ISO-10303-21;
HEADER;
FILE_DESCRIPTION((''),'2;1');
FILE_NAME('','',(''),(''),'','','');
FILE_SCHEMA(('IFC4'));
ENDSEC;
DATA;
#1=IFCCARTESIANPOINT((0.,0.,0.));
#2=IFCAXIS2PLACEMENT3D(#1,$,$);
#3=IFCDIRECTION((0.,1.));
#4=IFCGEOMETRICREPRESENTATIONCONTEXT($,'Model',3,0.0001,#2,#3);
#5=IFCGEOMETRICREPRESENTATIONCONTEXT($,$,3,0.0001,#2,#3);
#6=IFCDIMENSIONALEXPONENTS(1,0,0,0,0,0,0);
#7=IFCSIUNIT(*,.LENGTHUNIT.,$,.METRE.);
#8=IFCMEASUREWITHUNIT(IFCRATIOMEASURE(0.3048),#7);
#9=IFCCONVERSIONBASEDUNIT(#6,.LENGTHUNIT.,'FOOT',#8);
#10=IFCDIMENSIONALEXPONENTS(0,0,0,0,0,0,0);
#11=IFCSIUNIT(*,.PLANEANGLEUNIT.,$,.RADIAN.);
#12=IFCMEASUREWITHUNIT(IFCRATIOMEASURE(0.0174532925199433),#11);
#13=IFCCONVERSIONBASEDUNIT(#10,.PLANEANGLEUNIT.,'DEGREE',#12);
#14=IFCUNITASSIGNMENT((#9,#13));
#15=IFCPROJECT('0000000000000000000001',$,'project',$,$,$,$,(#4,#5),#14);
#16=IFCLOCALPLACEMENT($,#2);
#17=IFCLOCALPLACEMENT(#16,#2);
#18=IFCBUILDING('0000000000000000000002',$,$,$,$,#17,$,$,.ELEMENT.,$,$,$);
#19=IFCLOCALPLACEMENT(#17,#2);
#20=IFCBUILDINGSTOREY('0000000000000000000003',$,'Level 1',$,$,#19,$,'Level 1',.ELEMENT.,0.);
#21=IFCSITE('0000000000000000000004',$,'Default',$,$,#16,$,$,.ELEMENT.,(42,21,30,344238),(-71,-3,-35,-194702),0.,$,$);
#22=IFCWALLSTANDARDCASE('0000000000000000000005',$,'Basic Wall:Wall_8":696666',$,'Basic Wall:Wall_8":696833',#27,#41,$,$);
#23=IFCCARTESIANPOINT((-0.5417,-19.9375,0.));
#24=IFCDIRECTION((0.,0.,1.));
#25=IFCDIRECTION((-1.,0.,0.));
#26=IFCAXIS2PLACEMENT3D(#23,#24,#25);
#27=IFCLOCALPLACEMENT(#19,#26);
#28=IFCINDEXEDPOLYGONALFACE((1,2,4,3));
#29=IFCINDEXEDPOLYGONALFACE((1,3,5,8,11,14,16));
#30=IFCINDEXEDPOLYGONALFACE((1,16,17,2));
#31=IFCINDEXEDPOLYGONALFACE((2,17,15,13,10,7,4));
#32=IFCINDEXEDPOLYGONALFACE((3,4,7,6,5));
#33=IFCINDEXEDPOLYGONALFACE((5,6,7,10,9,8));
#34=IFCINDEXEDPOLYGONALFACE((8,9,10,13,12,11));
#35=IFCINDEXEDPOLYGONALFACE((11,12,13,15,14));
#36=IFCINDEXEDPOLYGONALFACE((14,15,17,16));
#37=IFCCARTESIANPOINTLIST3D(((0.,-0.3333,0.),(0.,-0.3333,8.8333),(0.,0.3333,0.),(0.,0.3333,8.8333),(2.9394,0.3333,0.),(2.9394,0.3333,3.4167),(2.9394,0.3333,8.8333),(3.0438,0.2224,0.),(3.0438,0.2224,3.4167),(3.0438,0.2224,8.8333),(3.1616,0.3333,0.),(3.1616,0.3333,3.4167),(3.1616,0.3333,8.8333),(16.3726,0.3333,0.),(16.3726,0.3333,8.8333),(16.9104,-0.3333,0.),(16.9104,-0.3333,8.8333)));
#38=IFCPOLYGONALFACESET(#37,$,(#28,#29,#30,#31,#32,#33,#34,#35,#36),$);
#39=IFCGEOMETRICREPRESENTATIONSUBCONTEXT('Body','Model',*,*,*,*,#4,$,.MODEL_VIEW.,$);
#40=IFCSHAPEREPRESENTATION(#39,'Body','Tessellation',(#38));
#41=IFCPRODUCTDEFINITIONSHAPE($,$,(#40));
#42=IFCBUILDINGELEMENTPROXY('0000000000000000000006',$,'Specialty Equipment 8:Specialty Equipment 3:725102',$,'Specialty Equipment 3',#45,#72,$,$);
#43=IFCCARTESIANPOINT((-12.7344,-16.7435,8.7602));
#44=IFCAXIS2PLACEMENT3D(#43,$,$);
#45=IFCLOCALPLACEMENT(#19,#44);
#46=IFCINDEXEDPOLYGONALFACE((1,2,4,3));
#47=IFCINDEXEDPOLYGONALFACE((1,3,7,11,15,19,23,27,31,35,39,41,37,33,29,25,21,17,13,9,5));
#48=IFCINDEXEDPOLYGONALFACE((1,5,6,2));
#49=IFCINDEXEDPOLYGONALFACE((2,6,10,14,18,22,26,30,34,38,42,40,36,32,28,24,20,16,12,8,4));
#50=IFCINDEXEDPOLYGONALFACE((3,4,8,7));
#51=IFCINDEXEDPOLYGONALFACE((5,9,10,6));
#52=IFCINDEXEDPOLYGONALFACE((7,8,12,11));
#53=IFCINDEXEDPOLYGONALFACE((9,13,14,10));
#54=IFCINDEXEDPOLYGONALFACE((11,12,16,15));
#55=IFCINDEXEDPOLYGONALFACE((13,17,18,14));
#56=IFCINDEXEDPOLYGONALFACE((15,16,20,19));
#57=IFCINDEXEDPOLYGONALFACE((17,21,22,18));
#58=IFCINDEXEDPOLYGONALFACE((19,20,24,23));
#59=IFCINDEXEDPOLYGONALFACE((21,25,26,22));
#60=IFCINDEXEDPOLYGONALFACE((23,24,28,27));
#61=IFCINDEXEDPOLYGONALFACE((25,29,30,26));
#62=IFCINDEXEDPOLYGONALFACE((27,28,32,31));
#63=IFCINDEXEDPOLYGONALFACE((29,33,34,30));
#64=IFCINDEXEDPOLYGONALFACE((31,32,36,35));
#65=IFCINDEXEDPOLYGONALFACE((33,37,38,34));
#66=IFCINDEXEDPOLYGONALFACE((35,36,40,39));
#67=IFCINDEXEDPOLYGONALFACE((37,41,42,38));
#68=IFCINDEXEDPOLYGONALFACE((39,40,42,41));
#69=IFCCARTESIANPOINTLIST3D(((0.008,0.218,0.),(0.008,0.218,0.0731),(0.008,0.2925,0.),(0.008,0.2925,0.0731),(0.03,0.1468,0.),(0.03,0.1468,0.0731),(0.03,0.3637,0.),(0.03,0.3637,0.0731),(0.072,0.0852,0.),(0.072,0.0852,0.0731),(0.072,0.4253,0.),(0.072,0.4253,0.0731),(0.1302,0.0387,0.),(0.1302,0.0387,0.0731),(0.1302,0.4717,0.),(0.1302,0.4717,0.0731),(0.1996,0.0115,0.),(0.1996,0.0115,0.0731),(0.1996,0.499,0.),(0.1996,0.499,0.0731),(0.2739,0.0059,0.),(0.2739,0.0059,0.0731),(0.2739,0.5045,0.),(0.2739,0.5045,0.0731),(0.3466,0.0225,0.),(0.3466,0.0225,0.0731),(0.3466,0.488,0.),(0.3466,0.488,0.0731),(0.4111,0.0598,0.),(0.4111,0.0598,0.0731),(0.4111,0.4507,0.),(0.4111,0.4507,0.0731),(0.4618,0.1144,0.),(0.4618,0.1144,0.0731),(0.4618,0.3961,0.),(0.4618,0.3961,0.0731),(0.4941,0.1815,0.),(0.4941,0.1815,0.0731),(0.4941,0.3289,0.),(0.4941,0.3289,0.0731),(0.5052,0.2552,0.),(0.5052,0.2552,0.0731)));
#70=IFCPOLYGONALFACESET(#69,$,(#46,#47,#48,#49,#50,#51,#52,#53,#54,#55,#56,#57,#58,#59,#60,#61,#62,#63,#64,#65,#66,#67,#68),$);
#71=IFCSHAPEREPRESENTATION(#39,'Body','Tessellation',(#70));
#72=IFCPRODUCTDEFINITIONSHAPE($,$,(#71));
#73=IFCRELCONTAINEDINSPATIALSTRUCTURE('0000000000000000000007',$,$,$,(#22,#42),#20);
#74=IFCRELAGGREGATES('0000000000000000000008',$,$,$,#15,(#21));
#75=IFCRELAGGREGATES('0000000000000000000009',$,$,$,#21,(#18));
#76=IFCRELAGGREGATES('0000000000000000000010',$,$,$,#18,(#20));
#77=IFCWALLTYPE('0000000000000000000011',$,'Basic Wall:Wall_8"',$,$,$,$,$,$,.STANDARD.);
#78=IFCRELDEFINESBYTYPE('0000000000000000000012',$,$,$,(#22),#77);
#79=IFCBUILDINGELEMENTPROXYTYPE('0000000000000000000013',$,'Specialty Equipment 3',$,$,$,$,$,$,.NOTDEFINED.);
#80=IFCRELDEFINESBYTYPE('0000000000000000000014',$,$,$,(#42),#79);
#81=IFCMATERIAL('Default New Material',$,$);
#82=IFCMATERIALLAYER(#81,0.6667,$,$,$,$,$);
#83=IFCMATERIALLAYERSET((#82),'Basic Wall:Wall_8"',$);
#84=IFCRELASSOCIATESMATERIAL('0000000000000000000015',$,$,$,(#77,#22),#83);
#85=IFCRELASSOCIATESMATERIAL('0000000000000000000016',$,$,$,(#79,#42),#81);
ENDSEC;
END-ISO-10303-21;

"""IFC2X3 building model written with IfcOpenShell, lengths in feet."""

from ifc_helpers import new_model, entity, si_unit, converted_unit, direction, frame, frame_2d, origin, place, context, subcontext, project, spatial, polyline, rectangle, circle, outline, extrude, source, transform, mapped, material, layer, layer_set, layer_usage, type_object, type_shapes, element, save


model = new_model("IFC2X3")

# Units and contexts
model_context = context("Model", 3, precision=0.0001, world=origin(), true_north=direction((0.0, 1.0)))
context_of_model = context(None, 3, precision=0.0001, world=origin(), true_north=direction((0.0, 1.0)))
body_context = subcontext(model_context, "Body", "Model", "MODEL_VIEW")
ifc_project = project(units=[converted_unit("LENGTHUNIT", "FOOT", entity("IfcRatioMeasure", 0.3048), si_unit("LENGTHUNIT", "METRE"), dimensions=[1, 0, 0, 0, 0, 0, 0]), converted_unit("PLANEANGLEUNIT", "DEGREE", entity("IfcRatioMeasure", 0.0174532925199433), si_unit("PLANEANGLEUNIT", "RADIAN"), dimensions=[0, 0, 0, 0, 0, 0, 0])], contexts=[model_context, context_of_model])

# Site, building, storey
site_placement = place(None, origin())
site = spatial("IfcSite", under=ifc_project, at=site_placement, Name="Default", CompositionType="ELEMENT", RefLatitude=(42, 21, 30, 344238), RefLongitude=(-71, -3, -35, -194702), RefElevation=0.0)
building_placement = place(site_placement, origin())
building = spatial("IfcBuilding", under=site, at=building_placement, CompositionType="ELEMENT")
storey_placement = place(building_placement, origin())
storey = spatial("IfcBuildingStorey", under=building, at=storey_placement, Name="Level 1", LongName="Level 1", CompositionType="ELEMENT", Elevation=0.0)

# Wall, opening
ifc_material = material(Name="Default New Material")
ifc_layer_1 = layer(ifc_material, 0.6667)
ifc_layer_set_1 = layer_set([ifc_layer_1], Name="Basic Wall:Wall_8\"")
wall_type_1 = type_object("IfcWallType", Name="Basic Wall:Wall_8\"", PredefinedType="STANDARD", material=ifc_layer_set_1)
ifc_layer_usage_1 = layer_usage(ifc_layer_set_1, "AXIS2", "NEGATIVE", 0.3333)
wall_1_placement = place(storey_placement, frame((-0.5417, -19.9375, 0.0), z_axis=(0.0, 0.0, 1.0), x_axis=(-1.0, 0.0, 0.0)))
wall_1 = element("IfcWallStandardCase", 1, at=wall_1_placement, inside=storey, type_object=wall_type_1, material=ifc_layer_usage_1, Name="Basic Wall:Wall_8\":696666", ObjectType="Basic Wall:Wall_8\":696833", context=body_context, shape_type="SweptSolid", body=[
    extrude(outline(polyline([(16.9104, -0.3333), (16.3726, 0.3333), (4.3125, 0.3333), (3.5688, 0.3333), (3.1616, 0.3333), (3.0438, 0.2224), (2.9394, 0.3333), (0.0, 0.3333), (0.0, -0.3333), (0.0417, -0.3333), (16.9104, -0.3333)])), origin(), (0.0, 0.0, 1.0), 8.8333),
])
opening_1_placement = place(wall_1_placement, frame((3.7721, 4.003, 0.0)))
element("IfcOpeningElement", 2, at=opening_1_placement, cuts=wall_1, ObjectType="Opening", context=body_context, shape_type="SweptSolid", body=[
    extrude(rectangle(XDim=3.4167, YDim=1.0, at=frame_2d((0.0, 0.0), x_axis=(0.0, 1.0))), frame((-0.3641, -3.4379, 1.7083), z_axis=(-0.685261, 0.728297, 0.0), x_axis=(0.728297, 0.685261, 0.0)), (0.0, 0.0, 1.0), 4.25),
])

# Building element proxy
building_element_proxy_type_1 = type_object("IfcBuildingElementProxyType", Name="Specialty Equipment 3", PredefinedType="NOTDEFINED", material=ifc_material)
shared_shape_1 = source(origin(), body_context, "Body", "SweptSolid", [
    extrude(circle(Radius=0.25, at=frame_2d((0.0, 0.0), x_axis=(1.0, 0.0))), frame((0.2552, 0.2552, 0.0)), (0.0, 0.0, 1.0), 0.0731),
])
type_shapes(building_element_proxy_type_1, [shared_shape_1])
proxy_1_placement = place(storey_placement, frame((-12.7344, -16.7435, 8.7602)))
element("IfcBuildingElementProxy", 3, at=proxy_1_placement, inside=storey, type_object=building_element_proxy_type_1, material=ifc_material, Name="Specialty Equipment 8:Specialty Equipment 3:725102", ObjectType="Specialty Equipment 3", context=body_context, shape_type="MappedRepresentation", body=[
    mapped(shared_shape_1, transform((0.0, 0.0, 0.0), scale=1.0)),
])

save(model, "model.ifc")
